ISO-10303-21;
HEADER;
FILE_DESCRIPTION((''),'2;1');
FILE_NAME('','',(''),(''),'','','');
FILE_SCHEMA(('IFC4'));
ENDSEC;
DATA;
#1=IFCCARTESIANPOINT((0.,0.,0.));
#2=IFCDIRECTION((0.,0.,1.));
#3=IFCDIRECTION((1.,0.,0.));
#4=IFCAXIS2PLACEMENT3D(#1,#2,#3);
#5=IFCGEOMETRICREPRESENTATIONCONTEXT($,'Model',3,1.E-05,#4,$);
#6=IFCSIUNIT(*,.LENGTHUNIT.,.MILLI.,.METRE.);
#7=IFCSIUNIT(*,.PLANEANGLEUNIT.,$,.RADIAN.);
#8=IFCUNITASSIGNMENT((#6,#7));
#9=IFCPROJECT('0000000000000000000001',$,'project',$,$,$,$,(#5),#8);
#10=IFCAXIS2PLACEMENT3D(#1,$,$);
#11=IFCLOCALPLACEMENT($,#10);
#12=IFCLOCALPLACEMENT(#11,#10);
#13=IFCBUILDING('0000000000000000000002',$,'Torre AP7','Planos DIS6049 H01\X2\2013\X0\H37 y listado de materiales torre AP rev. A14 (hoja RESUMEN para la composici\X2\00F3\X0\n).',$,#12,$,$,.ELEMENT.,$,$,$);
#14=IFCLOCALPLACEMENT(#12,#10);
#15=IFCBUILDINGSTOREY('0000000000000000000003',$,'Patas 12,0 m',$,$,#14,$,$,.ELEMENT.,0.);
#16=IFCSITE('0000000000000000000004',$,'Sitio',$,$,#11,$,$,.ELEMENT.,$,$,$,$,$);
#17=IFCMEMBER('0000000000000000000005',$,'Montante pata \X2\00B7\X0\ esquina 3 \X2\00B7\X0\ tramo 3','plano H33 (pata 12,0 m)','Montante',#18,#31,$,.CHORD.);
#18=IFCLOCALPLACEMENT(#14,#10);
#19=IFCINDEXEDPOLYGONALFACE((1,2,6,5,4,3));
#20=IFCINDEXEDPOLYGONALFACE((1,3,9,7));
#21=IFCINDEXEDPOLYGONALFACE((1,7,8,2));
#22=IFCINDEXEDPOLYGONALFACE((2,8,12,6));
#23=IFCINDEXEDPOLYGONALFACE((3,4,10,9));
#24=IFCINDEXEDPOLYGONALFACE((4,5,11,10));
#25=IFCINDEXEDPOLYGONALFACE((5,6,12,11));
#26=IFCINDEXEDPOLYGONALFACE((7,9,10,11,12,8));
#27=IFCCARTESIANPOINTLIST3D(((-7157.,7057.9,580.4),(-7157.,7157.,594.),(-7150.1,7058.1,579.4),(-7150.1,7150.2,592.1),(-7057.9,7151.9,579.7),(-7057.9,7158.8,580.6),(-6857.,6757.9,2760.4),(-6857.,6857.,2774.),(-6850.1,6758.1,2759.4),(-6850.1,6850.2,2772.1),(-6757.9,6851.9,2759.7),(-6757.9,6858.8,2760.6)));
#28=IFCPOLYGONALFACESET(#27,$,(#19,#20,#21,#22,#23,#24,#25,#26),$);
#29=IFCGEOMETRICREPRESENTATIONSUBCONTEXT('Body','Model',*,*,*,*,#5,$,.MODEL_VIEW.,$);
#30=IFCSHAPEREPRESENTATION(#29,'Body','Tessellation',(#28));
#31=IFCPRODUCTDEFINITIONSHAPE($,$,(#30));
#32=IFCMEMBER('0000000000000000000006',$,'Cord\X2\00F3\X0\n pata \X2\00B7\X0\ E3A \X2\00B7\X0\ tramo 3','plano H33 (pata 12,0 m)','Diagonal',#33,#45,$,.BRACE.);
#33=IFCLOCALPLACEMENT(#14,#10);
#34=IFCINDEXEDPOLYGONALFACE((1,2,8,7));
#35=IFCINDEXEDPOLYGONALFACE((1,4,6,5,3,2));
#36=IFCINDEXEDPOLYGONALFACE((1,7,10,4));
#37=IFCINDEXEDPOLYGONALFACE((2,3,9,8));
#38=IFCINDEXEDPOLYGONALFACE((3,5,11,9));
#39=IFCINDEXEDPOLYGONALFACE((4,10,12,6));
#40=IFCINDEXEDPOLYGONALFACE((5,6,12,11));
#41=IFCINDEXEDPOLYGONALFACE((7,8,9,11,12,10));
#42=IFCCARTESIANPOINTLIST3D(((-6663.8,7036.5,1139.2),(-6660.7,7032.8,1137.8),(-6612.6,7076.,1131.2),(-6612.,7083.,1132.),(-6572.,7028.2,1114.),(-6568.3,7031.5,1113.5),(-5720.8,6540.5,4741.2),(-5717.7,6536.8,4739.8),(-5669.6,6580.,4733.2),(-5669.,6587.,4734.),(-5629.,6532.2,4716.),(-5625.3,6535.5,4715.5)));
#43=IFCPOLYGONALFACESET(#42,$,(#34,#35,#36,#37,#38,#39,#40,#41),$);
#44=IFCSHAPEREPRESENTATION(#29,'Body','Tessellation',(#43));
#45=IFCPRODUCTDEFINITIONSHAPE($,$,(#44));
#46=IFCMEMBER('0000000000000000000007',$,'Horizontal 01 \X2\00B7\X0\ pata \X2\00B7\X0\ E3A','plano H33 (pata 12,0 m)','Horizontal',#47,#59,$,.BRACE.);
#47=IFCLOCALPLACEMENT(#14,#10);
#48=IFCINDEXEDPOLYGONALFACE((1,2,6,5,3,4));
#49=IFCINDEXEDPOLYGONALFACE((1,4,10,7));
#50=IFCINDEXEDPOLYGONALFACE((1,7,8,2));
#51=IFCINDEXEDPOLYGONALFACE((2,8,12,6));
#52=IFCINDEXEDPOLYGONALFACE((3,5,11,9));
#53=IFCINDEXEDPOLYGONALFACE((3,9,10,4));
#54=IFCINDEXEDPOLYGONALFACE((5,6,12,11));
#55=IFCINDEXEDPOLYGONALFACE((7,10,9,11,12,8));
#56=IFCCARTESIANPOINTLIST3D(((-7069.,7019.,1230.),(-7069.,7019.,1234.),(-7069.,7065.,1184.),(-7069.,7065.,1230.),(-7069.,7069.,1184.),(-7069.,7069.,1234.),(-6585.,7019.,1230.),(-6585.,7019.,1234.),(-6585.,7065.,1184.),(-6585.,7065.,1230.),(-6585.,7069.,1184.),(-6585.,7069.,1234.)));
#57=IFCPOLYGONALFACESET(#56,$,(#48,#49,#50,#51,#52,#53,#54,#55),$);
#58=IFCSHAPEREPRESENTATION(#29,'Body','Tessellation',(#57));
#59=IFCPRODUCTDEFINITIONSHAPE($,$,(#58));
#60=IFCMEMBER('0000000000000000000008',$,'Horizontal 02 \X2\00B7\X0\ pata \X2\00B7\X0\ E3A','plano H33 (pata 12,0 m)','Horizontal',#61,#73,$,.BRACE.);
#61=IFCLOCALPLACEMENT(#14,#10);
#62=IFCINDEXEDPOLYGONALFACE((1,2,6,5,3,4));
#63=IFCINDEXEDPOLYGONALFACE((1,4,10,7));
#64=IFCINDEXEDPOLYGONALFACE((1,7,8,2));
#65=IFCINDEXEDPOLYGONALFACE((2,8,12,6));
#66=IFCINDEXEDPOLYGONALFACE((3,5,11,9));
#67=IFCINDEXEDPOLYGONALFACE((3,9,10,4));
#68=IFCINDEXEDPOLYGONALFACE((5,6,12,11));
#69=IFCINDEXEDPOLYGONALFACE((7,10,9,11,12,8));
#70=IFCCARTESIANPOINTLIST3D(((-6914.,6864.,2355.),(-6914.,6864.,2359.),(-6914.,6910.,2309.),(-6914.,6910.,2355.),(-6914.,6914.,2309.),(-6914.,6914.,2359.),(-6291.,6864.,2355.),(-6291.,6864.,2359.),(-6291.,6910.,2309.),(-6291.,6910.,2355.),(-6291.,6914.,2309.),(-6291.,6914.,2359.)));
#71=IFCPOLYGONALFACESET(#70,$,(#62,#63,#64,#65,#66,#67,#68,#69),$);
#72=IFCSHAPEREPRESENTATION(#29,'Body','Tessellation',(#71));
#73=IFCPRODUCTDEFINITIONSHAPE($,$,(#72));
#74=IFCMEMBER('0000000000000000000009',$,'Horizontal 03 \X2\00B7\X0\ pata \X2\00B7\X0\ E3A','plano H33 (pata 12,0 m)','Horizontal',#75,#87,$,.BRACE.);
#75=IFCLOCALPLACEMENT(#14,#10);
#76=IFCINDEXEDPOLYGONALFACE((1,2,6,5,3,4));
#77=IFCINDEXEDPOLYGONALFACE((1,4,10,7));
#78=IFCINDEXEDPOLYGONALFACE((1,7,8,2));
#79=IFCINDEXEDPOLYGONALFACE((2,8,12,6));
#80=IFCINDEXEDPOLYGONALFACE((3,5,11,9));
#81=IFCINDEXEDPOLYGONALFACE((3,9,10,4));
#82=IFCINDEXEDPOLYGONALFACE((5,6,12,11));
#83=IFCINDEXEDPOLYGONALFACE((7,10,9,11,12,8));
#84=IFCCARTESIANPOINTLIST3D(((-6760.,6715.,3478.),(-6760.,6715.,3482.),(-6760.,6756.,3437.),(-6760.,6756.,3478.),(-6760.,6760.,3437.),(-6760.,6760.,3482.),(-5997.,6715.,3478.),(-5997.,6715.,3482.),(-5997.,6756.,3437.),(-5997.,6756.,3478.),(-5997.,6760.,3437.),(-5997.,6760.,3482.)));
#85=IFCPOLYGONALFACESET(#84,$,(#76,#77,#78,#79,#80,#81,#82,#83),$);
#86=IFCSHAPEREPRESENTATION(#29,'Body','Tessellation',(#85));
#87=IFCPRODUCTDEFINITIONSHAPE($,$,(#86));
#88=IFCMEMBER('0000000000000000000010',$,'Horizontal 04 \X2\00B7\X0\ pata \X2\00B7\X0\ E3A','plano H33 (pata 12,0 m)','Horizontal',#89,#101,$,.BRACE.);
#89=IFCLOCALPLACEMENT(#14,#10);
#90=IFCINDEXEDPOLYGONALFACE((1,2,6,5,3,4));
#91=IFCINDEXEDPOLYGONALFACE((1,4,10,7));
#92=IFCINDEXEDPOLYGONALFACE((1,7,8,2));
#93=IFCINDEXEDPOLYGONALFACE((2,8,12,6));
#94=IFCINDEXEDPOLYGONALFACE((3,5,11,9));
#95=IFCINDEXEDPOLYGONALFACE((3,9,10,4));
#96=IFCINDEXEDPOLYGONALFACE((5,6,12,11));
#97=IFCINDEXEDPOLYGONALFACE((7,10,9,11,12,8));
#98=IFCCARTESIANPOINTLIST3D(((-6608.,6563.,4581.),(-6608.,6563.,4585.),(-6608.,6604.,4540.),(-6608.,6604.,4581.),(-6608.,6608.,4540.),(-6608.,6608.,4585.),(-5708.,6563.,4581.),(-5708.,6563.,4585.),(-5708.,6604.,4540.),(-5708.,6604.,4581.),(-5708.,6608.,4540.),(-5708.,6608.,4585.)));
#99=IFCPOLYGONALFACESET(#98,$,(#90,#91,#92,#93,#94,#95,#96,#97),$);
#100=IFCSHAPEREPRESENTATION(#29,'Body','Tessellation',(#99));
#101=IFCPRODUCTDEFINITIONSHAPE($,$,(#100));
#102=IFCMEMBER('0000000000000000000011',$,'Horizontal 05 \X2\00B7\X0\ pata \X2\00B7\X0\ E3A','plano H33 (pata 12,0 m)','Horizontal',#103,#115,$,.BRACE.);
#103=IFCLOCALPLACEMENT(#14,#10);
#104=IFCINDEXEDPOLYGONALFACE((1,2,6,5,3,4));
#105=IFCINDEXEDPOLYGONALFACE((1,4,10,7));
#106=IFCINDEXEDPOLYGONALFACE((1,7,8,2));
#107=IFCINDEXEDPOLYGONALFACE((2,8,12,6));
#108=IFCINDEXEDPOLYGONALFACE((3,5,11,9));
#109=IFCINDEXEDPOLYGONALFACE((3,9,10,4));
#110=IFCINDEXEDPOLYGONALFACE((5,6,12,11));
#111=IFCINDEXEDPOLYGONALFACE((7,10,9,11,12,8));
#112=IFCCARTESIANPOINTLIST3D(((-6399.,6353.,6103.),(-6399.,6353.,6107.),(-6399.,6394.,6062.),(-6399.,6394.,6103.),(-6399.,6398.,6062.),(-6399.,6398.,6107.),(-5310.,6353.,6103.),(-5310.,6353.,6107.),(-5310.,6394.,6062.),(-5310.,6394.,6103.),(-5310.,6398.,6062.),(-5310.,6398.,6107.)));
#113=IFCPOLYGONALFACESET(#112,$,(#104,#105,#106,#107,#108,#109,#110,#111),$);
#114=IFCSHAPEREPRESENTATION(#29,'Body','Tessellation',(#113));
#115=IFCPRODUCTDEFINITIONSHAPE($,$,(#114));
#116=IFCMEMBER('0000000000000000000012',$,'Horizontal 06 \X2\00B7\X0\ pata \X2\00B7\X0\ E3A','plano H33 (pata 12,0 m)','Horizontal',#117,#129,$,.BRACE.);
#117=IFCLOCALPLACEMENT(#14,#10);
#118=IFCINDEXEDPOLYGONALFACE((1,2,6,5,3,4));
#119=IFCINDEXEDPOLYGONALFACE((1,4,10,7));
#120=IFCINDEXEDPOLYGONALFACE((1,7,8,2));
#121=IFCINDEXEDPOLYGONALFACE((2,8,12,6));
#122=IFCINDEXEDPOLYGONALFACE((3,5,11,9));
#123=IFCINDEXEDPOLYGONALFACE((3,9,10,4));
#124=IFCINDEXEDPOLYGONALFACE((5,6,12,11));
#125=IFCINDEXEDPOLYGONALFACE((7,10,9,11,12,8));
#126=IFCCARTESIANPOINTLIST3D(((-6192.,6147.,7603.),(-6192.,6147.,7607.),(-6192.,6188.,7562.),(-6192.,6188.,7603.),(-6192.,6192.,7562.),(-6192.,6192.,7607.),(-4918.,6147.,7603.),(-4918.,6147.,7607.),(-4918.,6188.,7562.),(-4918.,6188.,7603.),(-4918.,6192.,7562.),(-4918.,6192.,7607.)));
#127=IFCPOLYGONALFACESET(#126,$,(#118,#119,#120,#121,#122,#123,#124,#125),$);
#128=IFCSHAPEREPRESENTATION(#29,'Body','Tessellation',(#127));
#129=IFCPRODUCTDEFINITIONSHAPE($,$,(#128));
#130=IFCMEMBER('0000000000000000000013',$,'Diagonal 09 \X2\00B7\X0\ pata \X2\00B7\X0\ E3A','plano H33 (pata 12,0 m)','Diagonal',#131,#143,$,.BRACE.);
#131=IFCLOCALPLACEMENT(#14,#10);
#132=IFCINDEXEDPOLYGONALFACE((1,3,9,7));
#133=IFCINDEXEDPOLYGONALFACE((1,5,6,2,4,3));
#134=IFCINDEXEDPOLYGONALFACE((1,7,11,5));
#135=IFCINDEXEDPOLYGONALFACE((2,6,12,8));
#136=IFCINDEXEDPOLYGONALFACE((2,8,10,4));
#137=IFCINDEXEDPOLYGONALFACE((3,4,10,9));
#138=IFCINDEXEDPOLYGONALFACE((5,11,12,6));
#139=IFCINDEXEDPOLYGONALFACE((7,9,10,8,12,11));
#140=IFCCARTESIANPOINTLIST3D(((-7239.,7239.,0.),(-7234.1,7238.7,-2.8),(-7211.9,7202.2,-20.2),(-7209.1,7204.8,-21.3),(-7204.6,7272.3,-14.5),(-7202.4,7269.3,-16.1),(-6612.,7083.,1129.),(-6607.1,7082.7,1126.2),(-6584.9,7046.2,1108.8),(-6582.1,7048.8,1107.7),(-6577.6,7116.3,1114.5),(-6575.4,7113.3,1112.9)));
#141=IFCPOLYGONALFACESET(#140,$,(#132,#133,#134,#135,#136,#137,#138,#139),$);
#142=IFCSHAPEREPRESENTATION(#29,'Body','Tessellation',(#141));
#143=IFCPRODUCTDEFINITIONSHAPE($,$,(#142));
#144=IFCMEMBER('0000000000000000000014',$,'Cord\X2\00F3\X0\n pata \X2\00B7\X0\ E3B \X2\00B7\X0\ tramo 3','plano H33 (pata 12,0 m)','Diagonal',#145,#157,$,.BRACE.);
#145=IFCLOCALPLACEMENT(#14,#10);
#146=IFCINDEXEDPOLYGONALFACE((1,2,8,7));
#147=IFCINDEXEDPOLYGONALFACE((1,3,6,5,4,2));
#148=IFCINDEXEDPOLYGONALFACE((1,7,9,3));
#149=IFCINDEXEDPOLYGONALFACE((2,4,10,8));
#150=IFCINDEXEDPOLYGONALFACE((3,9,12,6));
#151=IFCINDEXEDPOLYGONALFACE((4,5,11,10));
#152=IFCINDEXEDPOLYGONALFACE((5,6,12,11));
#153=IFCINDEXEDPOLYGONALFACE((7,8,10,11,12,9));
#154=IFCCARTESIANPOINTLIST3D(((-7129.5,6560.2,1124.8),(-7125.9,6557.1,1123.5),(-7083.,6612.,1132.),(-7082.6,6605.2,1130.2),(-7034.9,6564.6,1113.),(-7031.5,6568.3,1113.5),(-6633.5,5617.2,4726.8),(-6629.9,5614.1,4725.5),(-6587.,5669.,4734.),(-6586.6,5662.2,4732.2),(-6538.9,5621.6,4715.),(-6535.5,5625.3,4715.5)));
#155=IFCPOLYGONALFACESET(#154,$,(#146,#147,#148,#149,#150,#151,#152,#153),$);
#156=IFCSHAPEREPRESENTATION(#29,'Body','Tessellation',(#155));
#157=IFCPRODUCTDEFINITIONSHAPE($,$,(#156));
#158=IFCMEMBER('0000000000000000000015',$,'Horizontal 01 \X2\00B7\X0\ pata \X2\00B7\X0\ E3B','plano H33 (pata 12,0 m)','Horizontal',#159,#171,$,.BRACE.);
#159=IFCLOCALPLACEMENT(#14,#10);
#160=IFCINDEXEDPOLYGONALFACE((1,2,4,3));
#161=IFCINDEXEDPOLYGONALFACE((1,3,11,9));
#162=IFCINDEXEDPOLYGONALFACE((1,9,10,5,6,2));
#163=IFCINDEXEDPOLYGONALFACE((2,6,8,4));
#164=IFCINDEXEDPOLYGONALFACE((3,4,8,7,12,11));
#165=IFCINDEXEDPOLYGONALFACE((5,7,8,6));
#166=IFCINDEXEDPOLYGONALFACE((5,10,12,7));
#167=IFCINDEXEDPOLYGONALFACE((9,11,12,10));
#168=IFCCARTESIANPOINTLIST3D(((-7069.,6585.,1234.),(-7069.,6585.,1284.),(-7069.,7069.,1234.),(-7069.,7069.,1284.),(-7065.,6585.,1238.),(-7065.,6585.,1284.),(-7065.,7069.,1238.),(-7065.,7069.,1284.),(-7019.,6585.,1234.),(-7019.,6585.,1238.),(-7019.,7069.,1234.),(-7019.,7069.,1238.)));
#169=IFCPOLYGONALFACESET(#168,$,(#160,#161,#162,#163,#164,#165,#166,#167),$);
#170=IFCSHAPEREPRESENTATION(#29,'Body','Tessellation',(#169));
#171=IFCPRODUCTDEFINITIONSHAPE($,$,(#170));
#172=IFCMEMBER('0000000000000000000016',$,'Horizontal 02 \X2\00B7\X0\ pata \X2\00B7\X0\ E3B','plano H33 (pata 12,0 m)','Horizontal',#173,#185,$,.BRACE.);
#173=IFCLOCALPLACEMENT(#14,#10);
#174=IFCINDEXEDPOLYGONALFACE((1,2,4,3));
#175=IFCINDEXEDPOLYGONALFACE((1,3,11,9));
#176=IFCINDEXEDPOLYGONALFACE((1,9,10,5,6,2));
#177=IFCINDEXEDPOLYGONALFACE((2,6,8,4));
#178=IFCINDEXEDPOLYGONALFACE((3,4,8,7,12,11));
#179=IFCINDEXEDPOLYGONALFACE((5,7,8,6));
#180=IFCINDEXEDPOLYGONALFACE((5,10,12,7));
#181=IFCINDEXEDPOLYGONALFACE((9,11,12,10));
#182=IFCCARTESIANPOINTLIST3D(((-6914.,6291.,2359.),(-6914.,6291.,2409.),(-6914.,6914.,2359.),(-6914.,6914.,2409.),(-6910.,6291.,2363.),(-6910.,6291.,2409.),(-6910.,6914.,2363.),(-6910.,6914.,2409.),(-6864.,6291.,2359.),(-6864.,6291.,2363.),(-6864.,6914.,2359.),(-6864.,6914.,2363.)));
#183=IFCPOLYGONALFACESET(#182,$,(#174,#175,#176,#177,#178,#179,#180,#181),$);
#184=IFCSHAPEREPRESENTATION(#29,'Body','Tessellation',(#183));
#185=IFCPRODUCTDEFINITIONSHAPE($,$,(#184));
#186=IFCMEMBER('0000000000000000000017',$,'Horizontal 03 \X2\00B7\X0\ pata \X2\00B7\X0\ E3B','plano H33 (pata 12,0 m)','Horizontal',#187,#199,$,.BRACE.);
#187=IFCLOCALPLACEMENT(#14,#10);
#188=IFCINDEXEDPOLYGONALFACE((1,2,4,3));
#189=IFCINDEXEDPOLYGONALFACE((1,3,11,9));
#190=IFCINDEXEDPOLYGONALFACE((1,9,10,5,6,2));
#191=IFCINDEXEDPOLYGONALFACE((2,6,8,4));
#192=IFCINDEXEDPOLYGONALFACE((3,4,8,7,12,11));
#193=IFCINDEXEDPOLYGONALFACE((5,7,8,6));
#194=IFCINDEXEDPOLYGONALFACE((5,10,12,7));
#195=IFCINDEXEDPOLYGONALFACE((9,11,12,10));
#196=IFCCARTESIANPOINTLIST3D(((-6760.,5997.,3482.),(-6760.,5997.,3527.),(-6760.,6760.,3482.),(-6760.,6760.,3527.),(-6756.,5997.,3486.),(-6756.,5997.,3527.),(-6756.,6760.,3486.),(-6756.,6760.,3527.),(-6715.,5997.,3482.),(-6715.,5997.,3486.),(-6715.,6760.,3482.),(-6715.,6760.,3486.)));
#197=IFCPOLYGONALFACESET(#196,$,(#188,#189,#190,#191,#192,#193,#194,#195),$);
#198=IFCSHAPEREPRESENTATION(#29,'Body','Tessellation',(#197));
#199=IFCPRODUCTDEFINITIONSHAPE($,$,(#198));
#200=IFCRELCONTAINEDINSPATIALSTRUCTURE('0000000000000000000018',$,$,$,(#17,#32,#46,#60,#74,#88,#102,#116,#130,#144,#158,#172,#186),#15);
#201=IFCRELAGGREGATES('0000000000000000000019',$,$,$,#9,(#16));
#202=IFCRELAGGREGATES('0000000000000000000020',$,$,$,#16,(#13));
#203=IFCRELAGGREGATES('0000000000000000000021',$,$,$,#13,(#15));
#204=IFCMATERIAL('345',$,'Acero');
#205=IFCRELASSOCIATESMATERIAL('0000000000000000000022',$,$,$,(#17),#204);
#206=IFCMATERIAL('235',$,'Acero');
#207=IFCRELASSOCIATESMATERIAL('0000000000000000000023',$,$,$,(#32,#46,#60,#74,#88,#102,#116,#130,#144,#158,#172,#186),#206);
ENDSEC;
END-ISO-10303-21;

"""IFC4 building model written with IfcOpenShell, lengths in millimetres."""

from ifc_helpers import new_model, si_unit, frame, frame_2d, origin, origin_with_axes, place, context, subcontext, project, spatial, l_section, extrude, material, element, save


model = new_model("IFC4")

# Units and contexts
model_context = context("Model", 3, precision=1e-05, world=origin_with_axes())
body_context = subcontext(model_context, "Body", "Model", "MODEL_VIEW")
ifc_project = project(units=[si_unit("LENGTHUNIT", "METRE", prefix="MILLI"), si_unit("PLANEANGLEUNIT", "RADIAN")], contexts=[model_context])

# Site, building, storey
site_placement = place(None, origin())
site = spatial("IfcSite", under=ifc_project, at=site_placement, Name="Sitio", CompositionType="ELEMENT")
building_placement = place(site_placement, origin())
building = spatial("IfcBuilding", under=site, at=building_placement, Name="Torre AP7", Description="Planos DIS6049 H01–H37 y listado de materiales torre AP rev. A14 (hoja RESUMEN para la composición).", CompositionType="ELEMENT")
storey_placement = place(building_placement, origin())
storey = spatial("IfcBuildingStorey", under=building, at=storey_placement, Name="Patas 12,0 m", CompositionType="ELEMENT", Elevation=0.0)

# Members
ifc_material_1 = material(Name="345", Category="Acero")
member_1_placement = place(storey_placement, frame((-6857.0, 6857.0, 2774.0), z_axis=(-0.13508, 0.13508, -0.981584), x_axis=(0.990835, 0.018415, -0.133819)))
element("IfcMember", 1, at=member_1_placement, inside=storey, material=ifc_material_1, Name="Montante pata · esquina 3 · tramo 3", Description="plano H33 (pata 12,0 m)", ObjectType="Montante", PredefinedType="CHORD", context=body_context, shape_type="SweptSolid", body=[
    extrude(l_section(Depth=100.0, Width=100.0, Thickness=7.0, at=frame_2d((50.0, 50.0))), None, (0.0, 0.0, 1.0), 2220.9),
])
ifc_material_2 = material(Name="235", Category="Acero")
member_2_placement = place(storey_placement, frame((-5669.0, 6587.0, 4734.0), z_axis=(-0.251046, 0.132045, -0.958926), x_axis=(0.624006, -0.735254, -0.26461)))
element("IfcMember", 2, at=member_2_placement, inside=storey, material=ifc_material_2, Name="Cordón pata · E3A · tramo 3", Description="plano H33 (pata 12,0 m)", ObjectType="Diagonal", PredefinedType="BRACE", context=body_context, shape_type="SweptSolid", body=[
    extrude(l_section(Depth=70.0, Width=70.0, Thickness=5.0, at=frame_2d((35.0, 35.0))), None, (0.0, 0.0, 1.0), 3756.3),
])
member_3_placement = place(storey_placement, frame((-7069.0, 7069.0, 1234.0), z_axis=(1.0, 0.0, 0.0), x_axis=(0.0, -1.0, 0.0)))
element("IfcMember", 3, at=member_3_placement, inside=storey, material=ifc_material_2, Name="Horizontal 01 · pata · E3A", Description="plano H33 (pata 12,0 m)", ObjectType="Horizontal", PredefinedType="BRACE", context=body_context, shape_type="SweptSolid", body=[
    extrude(l_section(Depth=50.0, Width=50.0, Thickness=4.0, at=frame_2d((25.0, 25.0))), None, (0.0, 0.0, 1.0), 484.0),
])
member_4_placement = place(storey_placement, frame((-6914.0, 6914.0, 2359.0), z_axis=(1.0, 0.0, 0.0), x_axis=(0.0, -1.0, 0.0)))
element("IfcMember", 4, at=member_4_placement, inside=storey, material=ifc_material_2, Name="Horizontal 02 · pata · E3A", Description="plano H33 (pata 12,0 m)", ObjectType="Horizontal", PredefinedType="BRACE", context=body_context, shape_type="SweptSolid", body=[
    extrude(l_section(Depth=50.0, Width=50.0, Thickness=4.0, at=frame_2d((25.0, 25.0))), None, (0.0, 0.0, 1.0), 623.0),
])
member_5_placement = place(storey_placement, frame((-6760.0, 6760.0, 3482.0), z_axis=(1.0, 0.0, 0.0), x_axis=(0.0, -1.0, 0.0)))
element("IfcMember", 5, at=member_5_placement, inside=storey, material=ifc_material_2, Name="Horizontal 03 · pata · E3A", Description="plano H33 (pata 12,0 m)", ObjectType="Horizontal", PredefinedType="BRACE", context=body_context, shape_type="SweptSolid", body=[
    extrude(l_section(Depth=45.0, Width=45.0, Thickness=4.0, at=frame_2d((22.5, 22.5))), None, (0.0, 0.0, 1.0), 763.0),
])
member_6_placement = place(storey_placement, frame((-6608.0, 6608.0, 4585.0), z_axis=(1.0, 0.0, 0.0), x_axis=(0.0, -1.0, 0.0)))
element("IfcMember", 6, at=member_6_placement, inside=storey, material=ifc_material_2, Name="Horizontal 04 · pata · E3A", Description="plano H33 (pata 12,0 m)", ObjectType="Horizontal", PredefinedType="BRACE", context=body_context, shape_type="SweptSolid", body=[
    extrude(l_section(Depth=45.0, Width=45.0, Thickness=4.0, at=frame_2d((22.5, 22.5))), None, (0.0, 0.0, 1.0), 900.0),
])
member_7_placement = place(storey_placement, frame((-6399.0, 6398.0, 6107.0), z_axis=(1.0, 0.0, 0.0), x_axis=(0.0, -1.0, 0.0)))
element("IfcMember", 7, at=member_7_placement, inside=storey, material=ifc_material_2, Name="Horizontal 05 · pata · E3A", Description="plano H33 (pata 12,0 m)", ObjectType="Horizontal", PredefinedType="BRACE", context=body_context, shape_type="SweptSolid", body=[
    extrude(l_section(Depth=45.0, Width=45.0, Thickness=4.0, at=frame_2d((22.5, 22.5))), None, (0.0, 0.0, 1.0), 1089.0),
])
member_8_placement = place(storey_placement, frame((-6192.0, 6192.0, 7607.0), z_axis=(1.0, 0.0, 0.0), x_axis=(0.0, -1.0, 0.0)))
element("IfcMember", 8, at=member_8_placement, inside=storey, material=ifc_material_2, Name="Horizontal 06 · pata · E3A", Description="plano H33 (pata 12,0 m)", ObjectType="Horizontal", PredefinedType="BRACE", context=body_context, shape_type="SweptSolid", body=[
    extrude(l_section(Depth=45.0, Width=45.0, Thickness=4.0, at=frame_2d((22.5, 22.5))), None, (0.0, 0.0, 1.0), 1274.0),
])
member_9_placement = place(storey_placement, frame((-7239.0, 7239.0, 0.0), z_axis=(0.482007, -0.119925, 0.867921), x_axis=(0.542627, -0.73689, -0.403173)))
element("IfcMember", 9, at=member_9_placement, inside=storey, material=ifc_material_2, Name="Diagonal 09 · pata · E3A", Description="plano H33 (pata 12,0 m)", ObjectType="Diagonal", PredefinedType="BRACE", context=body_context, shape_type="SweptSolid", body=[
    extrude(l_section(Depth=50.0, Width=50.0, Thickness=4.0, at=frame_2d((25.0, 25.0))), None, (0.0, 0.0, 1.0), 1300.8),
])
member_10_placement = place(storey_placement, frame((-6587.0, 5669.0, 4734.0), z_axis=(-0.132045, 0.251046, -0.958926), x_axis=(0.735254, -0.624006, -0.26461)))
element("IfcMember", 10, at=member_10_placement, inside=storey, material=ifc_material_2, Name="Cordón pata · E3B · tramo 3", Description="plano H33 (pata 12,0 m)", ObjectType="Diagonal", PredefinedType="BRACE", context=body_context, shape_type="SweptSolid", body=[
    extrude(l_section(Depth=70.0, Width=70.0, Thickness=5.0, at=frame_2d((35.0, 35.0))), None, (0.0, 0.0, 1.0), 3756.3),
])
member_11_placement = place(storey_placement, frame((-7069.0, 7069.0, 1234.0), z_axis=(0.0, -1.0, 0.0), x_axis=(1.0, 0.0, 0.0)))
element("IfcMember", 11, at=member_11_placement, inside=storey, material=ifc_material_2, Name="Horizontal 01 · pata · E3B", Description="plano H33 (pata 12,0 m)", ObjectType="Horizontal", PredefinedType="BRACE", context=body_context, shape_type="SweptSolid", body=[
    extrude(l_section(Depth=50.0, Width=50.0, Thickness=4.0, at=frame_2d((25.0, 25.0))), None, (0.0, 0.0, 1.0), 484.0),
])
member_12_placement = place(storey_placement, frame((-6914.0, 6914.0, 2359.0), z_axis=(0.0, -1.0, 0.0), x_axis=(1.0, 0.0, 0.0)))
element("IfcMember", 12, at=member_12_placement, inside=storey, material=ifc_material_2, Name="Horizontal 02 · pata · E3B", Description="plano H33 (pata 12,0 m)", ObjectType="Horizontal", PredefinedType="BRACE", context=body_context, shape_type="SweptSolid", body=[
    extrude(l_section(Depth=50.0, Width=50.0, Thickness=4.0, at=frame_2d((25.0, 25.0))), None, (0.0, 0.0, 1.0), 623.0),
])
member_13_placement = place(storey_placement, frame((-6760.0, 6760.0, 3482.0), z_axis=(0.0, -1.0, 0.0), x_axis=(1.0, 0.0, 0.0)))
element("IfcMember", 13, at=member_13_placement, inside=storey, material=ifc_material_2, Name="Horizontal 03 · pata · E3B", Description="plano H33 (pata 12,0 m)", ObjectType="Horizontal", PredefinedType="BRACE", context=body_context, shape_type="SweptSolid", body=[
    extrude(l_section(Depth=45.0, Width=45.0, Thickness=4.0, at=frame_2d((22.5, 22.5))), None, (0.0, 0.0, 1.0), 763.0),
])

save(model, "model.ifc")
